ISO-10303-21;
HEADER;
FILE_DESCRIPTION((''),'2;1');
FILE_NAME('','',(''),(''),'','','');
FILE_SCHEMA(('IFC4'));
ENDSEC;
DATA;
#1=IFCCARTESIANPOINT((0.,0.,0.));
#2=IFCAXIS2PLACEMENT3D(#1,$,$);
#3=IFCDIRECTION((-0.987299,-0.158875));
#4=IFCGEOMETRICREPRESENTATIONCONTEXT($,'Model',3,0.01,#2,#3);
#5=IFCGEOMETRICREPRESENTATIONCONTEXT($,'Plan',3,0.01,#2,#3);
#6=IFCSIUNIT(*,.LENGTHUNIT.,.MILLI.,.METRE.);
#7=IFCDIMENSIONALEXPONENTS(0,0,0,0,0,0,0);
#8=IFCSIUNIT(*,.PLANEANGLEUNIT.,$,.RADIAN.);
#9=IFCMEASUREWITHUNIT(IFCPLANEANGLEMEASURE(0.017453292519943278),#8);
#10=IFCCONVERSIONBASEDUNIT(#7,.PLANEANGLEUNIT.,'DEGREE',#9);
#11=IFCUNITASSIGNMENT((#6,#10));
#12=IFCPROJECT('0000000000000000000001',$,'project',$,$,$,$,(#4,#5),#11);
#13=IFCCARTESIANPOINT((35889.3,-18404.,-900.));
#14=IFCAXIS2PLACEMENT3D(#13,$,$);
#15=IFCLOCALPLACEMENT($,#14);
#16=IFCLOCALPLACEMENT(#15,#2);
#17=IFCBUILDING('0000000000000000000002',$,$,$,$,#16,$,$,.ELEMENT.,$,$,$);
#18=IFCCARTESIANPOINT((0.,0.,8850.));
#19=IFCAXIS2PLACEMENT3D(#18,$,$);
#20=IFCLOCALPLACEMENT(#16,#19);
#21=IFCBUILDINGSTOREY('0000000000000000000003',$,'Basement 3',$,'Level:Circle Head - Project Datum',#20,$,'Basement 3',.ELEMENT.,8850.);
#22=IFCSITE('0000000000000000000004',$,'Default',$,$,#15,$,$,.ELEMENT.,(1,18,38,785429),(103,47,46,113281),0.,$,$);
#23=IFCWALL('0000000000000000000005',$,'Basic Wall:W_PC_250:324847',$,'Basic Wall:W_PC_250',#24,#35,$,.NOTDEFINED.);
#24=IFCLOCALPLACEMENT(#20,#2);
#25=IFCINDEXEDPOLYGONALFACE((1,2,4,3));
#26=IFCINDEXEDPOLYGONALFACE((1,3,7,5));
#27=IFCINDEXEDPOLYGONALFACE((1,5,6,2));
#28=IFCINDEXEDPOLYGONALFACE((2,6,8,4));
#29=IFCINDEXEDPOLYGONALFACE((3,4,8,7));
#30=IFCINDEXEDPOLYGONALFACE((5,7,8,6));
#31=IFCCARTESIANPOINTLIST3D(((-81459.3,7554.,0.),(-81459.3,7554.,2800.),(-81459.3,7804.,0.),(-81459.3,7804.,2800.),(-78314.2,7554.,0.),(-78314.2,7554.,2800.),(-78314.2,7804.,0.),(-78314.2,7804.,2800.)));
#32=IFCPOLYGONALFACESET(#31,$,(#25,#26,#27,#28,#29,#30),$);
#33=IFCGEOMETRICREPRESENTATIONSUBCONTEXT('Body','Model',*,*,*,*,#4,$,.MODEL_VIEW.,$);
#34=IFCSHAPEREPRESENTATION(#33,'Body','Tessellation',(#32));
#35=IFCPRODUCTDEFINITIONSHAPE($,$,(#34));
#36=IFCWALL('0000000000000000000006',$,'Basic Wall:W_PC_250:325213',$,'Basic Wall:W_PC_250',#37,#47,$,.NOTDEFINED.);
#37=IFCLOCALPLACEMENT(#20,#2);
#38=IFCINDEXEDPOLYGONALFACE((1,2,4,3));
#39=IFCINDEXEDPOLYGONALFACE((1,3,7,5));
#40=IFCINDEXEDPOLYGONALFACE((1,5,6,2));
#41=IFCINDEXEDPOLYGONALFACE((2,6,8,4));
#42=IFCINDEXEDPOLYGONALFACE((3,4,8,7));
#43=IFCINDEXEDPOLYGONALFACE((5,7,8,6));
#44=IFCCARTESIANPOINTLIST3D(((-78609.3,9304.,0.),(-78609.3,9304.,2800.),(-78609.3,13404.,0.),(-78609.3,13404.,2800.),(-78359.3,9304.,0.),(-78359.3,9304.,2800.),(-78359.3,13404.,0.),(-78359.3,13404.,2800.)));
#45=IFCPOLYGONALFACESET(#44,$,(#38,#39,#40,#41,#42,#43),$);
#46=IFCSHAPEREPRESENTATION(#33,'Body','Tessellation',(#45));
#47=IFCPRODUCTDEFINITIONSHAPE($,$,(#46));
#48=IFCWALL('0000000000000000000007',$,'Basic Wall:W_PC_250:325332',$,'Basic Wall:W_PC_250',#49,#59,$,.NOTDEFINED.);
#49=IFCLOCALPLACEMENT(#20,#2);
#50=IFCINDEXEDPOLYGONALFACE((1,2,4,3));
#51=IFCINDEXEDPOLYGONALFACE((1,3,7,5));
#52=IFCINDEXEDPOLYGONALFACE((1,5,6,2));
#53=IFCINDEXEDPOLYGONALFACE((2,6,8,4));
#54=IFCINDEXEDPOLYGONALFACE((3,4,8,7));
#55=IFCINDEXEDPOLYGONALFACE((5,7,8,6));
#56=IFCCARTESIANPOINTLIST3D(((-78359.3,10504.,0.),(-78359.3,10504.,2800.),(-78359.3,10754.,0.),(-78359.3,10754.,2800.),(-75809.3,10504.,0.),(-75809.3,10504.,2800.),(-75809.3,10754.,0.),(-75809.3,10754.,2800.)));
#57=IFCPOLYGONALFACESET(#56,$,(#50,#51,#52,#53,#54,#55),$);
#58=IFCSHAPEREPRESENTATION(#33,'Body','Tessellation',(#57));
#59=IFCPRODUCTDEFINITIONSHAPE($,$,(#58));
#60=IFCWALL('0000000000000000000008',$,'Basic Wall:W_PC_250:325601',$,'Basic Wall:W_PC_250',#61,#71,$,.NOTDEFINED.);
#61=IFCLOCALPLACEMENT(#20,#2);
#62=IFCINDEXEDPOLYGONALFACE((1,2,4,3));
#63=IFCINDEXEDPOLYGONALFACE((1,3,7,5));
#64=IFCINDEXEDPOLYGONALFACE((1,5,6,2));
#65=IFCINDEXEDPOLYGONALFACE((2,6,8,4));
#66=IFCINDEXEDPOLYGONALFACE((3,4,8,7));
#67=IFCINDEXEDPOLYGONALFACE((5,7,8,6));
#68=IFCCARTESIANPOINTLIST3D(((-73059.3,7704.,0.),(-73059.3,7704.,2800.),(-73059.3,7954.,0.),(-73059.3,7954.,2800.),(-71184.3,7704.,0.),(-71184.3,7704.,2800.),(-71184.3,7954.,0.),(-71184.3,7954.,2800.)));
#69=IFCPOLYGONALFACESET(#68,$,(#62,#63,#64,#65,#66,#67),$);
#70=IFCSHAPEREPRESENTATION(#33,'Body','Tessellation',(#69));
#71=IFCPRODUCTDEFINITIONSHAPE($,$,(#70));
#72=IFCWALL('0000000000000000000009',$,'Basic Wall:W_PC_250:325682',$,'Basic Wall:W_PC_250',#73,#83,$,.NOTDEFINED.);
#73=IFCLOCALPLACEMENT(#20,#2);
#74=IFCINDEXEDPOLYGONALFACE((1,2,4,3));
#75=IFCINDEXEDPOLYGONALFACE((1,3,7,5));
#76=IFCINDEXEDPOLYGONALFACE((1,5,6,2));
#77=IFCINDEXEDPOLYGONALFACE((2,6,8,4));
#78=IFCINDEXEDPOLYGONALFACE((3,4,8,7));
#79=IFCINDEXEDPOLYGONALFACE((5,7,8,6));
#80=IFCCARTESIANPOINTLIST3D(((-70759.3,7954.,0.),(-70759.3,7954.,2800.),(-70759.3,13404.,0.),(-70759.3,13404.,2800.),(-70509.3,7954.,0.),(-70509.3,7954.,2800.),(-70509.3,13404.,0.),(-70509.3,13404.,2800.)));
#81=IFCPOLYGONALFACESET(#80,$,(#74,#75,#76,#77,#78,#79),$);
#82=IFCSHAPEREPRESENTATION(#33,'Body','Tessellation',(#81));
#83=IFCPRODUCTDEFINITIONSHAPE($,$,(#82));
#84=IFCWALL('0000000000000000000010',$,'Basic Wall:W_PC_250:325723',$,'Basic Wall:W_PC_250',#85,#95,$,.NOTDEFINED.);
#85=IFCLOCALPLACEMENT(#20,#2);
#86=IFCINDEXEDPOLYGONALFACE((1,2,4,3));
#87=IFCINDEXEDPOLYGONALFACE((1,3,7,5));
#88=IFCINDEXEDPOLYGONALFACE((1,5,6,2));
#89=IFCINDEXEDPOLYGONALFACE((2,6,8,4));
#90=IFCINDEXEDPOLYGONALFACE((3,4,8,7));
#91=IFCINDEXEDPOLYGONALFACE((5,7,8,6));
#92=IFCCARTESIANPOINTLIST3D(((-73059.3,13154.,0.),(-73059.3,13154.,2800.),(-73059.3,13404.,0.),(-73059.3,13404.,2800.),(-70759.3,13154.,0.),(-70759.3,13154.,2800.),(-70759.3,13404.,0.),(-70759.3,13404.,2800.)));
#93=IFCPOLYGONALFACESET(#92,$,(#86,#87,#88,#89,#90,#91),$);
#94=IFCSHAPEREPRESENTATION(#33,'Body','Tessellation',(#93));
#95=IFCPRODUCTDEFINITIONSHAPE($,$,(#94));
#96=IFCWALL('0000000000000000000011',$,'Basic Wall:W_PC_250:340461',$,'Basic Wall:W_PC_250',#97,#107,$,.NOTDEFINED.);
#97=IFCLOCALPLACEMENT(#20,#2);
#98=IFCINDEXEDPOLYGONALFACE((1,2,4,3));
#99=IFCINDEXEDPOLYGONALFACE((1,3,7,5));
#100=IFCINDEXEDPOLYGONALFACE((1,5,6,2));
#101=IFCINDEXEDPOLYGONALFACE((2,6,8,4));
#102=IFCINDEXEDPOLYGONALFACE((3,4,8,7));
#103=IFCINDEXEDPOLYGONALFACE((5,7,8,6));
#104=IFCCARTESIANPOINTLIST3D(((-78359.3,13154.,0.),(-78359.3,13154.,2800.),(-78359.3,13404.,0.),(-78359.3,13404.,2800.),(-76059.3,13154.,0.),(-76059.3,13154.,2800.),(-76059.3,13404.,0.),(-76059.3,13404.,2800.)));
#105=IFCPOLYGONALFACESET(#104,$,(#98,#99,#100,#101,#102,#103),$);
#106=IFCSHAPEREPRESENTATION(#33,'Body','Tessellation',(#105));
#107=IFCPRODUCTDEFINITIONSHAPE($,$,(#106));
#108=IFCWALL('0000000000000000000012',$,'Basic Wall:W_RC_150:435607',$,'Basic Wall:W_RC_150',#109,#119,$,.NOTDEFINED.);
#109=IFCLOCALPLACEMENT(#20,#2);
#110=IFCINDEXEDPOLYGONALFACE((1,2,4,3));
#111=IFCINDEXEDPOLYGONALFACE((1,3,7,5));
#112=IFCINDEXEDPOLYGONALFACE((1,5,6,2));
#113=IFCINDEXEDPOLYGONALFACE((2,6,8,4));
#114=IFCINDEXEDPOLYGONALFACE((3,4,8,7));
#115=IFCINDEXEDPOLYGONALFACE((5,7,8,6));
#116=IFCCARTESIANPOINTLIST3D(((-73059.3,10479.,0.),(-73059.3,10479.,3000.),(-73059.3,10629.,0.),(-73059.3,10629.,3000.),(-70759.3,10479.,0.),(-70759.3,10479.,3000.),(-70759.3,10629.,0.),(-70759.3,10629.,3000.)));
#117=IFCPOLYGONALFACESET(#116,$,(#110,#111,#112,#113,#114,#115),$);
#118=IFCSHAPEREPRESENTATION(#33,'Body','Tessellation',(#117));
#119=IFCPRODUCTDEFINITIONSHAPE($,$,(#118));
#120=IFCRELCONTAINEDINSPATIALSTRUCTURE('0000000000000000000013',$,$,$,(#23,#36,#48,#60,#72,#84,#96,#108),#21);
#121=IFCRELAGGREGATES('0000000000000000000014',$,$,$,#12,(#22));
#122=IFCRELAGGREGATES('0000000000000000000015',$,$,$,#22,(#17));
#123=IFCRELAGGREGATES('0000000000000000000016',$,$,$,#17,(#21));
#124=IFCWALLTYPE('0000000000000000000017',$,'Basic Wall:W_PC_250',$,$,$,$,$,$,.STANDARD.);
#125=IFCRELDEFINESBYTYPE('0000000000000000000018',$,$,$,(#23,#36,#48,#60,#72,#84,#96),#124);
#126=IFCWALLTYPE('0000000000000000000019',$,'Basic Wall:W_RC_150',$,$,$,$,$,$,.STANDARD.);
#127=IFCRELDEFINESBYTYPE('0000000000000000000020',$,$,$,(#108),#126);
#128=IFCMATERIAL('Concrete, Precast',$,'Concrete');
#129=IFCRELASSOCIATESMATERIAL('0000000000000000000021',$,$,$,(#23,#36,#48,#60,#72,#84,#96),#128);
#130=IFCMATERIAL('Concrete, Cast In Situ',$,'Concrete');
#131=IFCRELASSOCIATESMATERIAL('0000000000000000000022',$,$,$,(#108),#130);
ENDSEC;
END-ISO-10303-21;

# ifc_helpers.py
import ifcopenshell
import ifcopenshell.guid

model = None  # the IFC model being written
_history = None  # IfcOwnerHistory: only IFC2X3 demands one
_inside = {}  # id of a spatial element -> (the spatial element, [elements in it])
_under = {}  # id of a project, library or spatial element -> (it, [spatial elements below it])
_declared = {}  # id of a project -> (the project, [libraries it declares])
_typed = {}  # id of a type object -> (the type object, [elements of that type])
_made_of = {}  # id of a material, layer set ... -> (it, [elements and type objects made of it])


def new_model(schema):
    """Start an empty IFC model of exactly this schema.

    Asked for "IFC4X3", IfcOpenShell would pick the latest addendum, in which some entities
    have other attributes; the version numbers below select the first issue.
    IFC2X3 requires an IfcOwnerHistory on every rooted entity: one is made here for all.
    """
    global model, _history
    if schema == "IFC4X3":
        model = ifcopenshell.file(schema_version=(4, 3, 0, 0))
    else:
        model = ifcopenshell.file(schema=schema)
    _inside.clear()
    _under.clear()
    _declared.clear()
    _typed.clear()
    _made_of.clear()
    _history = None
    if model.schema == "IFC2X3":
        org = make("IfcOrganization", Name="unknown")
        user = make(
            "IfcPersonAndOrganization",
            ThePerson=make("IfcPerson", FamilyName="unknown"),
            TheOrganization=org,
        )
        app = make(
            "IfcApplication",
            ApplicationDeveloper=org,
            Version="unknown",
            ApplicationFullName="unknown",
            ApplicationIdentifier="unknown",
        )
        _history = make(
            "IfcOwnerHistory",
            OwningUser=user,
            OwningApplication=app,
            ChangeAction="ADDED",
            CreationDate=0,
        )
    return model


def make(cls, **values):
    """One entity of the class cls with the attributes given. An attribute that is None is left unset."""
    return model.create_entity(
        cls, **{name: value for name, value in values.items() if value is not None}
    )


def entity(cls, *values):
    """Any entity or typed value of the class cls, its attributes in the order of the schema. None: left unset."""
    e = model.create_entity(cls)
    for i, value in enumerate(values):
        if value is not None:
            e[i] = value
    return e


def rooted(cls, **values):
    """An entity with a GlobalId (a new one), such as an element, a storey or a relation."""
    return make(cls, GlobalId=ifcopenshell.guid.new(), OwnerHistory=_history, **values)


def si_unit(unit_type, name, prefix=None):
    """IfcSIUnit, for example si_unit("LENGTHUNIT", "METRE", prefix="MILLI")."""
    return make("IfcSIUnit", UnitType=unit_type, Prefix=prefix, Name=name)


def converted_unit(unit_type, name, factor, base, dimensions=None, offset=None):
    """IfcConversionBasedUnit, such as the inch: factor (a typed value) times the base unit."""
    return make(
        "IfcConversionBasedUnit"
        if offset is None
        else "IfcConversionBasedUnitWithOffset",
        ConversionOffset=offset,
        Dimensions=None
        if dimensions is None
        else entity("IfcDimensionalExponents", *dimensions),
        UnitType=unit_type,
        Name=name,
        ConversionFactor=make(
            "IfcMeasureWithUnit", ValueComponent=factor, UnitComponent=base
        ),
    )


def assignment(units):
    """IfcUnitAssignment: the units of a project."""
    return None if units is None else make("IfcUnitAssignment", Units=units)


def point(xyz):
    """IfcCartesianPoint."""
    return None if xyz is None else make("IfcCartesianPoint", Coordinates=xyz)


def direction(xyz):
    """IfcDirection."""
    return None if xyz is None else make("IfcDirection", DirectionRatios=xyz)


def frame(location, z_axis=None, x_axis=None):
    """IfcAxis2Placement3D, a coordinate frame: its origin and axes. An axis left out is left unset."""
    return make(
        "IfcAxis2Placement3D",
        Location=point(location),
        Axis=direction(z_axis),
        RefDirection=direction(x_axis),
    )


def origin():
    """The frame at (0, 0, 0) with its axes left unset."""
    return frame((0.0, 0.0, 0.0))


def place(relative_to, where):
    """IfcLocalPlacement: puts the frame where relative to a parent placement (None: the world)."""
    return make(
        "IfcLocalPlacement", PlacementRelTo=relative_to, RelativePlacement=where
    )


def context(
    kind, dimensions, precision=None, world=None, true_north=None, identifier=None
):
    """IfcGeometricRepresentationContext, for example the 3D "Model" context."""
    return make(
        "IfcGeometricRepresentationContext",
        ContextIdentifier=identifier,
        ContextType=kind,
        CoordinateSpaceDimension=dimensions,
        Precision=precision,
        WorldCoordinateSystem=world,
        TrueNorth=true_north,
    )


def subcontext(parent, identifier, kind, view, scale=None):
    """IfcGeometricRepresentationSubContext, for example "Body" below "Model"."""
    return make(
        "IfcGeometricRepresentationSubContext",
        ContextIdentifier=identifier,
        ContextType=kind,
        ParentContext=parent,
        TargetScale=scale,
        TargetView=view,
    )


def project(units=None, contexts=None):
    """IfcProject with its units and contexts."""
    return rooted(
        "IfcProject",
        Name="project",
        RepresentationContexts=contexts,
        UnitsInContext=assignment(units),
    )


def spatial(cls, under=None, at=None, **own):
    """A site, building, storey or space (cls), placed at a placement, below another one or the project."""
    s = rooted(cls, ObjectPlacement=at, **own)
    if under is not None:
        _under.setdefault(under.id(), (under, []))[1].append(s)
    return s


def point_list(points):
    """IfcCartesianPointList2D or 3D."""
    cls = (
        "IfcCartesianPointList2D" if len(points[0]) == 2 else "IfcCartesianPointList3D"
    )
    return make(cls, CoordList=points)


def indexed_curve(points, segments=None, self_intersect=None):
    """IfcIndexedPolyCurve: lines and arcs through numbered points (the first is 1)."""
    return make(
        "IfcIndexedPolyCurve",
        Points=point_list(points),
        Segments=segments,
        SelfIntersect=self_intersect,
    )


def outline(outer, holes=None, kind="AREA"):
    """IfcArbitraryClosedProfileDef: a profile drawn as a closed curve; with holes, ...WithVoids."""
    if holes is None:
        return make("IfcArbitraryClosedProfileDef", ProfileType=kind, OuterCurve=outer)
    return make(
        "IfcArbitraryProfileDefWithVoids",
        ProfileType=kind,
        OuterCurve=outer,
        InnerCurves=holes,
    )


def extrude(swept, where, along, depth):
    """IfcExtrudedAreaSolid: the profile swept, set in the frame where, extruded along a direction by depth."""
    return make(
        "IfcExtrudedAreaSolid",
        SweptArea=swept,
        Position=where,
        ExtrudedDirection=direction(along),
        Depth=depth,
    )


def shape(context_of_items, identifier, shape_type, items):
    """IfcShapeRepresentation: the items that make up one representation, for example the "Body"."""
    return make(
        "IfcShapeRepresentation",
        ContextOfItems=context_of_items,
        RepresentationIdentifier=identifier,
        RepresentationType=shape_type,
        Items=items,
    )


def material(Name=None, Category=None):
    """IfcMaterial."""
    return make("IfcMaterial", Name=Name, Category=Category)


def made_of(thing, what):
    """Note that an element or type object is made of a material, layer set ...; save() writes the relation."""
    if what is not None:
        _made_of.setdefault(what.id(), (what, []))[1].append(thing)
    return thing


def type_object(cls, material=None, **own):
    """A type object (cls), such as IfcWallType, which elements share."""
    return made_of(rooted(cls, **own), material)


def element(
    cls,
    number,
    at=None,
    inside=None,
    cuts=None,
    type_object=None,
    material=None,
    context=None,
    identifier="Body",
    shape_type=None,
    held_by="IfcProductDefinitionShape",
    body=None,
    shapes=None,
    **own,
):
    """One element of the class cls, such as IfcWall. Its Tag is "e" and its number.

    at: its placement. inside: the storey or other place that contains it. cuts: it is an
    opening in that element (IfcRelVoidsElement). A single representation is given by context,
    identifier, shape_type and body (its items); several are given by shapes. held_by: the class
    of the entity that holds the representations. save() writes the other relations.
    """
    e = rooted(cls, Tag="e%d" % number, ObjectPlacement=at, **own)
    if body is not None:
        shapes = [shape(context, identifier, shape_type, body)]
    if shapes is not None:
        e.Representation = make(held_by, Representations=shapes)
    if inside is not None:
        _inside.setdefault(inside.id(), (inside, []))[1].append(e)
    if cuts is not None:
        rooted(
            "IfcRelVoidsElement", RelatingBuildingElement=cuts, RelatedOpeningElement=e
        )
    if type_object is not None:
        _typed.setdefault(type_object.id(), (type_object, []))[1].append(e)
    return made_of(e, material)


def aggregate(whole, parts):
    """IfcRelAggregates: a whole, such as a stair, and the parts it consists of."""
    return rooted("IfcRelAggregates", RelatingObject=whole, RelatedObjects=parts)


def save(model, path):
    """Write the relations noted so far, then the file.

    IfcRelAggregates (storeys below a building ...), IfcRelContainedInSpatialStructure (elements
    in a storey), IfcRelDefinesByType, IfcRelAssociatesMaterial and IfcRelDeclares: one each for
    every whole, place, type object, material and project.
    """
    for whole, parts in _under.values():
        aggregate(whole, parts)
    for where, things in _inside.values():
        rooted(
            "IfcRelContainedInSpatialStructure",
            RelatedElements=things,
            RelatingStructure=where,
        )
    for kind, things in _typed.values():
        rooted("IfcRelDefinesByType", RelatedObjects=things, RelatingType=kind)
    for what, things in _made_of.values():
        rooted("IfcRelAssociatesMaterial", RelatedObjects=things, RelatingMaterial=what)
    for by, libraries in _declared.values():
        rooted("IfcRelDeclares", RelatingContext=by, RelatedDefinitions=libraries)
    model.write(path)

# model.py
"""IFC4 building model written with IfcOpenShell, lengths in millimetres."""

from ifc_helpers import new_model, entity, si_unit, converted_unit, direction, frame, origin, place, context, subcontext, project, spatial, indexed_curve, outline, extrude, material, type_object, element, save


model = new_model("IFC4")

# Units and contexts
model_context = context("Model", 3, precision=0.01, world=origin(), true_north=direction((-0.987299, -0.158875)))
plan_context = context("Plan", 3, precision=0.01, world=origin(), true_north=direction((-0.987299, -0.158875)))
body_context = subcontext(model_context, "Body", "Model", "MODEL_VIEW")
ifc_project = project(units=[si_unit("LENGTHUNIT", "METRE", prefix="MILLI"), converted_unit("PLANEANGLEUNIT", "DEGREE", entity("IfcPlaneAngleMeasure", 0.017453292519943278), si_unit("PLANEANGLEUNIT", "RADIAN"), dimensions=[0, 0, 0, 0, 0, 0, 0])], contexts=[model_context, plan_context])

# Site, building, storey
site_placement = place(None, frame((35889.3, -18404.0, -900.0)))
site = spatial("IfcSite", under=ifc_project, at=site_placement, Name="Default", CompositionType="ELEMENT", RefLatitude=(1, 18, 38, 785429), RefLongitude=(103, 47, 46, 113281), RefElevation=0.0)
building_placement = place(site_placement, origin())
building = spatial("IfcBuilding", under=site, at=building_placement, CompositionType="ELEMENT")
storey_placement = place(building_placement, frame((0.0, 0.0, 8850.0)))
storey = spatial("IfcBuildingStorey", under=building, at=storey_placement, Name="Basement 3", ObjectType="Level:Circle Head - Project Datum", LongName="Basement 3", CompositionType="ELEMENT", Elevation=8850.0)

# Walls
ifc_material_1 = material(Name="Concrete, Cast In Situ", Category="Concrete")
ifc_material_2 = material(Name="Concrete, Precast", Category="Concrete")
wall_type_1 = type_object("IfcWallType", Name="Basic Wall:W_PC_250", PredefinedType="STANDARD")
wall_1_placement = place(storey_placement, frame((-81459.3, 7679.0, 0.0)))
element("IfcWall", 1, at=wall_1_placement, inside=storey, type_object=wall_type_1, material=ifc_material_2, Name="Basic Wall:W_PC_250:324847", ObjectType="Basic Wall:W_PC_250", PredefinedType="NOTDEFINED", context=body_context, shape_type="SweptSolid", body=[
    extrude(outline(indexed_curve([(3145.2, 125.0), (0.0, 125.0), (0.0, -125.0), (3145.2, -125.0), (3145.2, 125.0)], self_intersect=False)), origin(), (0.0, 0.0, 1.0), 2800.0),
])
wall_2_placement = place(storey_placement, frame((-78484.3, 9304.0, 0.0), z_axis=(0.0, 0.0, 1.0), x_axis=(0.0, 1.0, 0.0)))
element("IfcWall", 2, at=wall_2_placement, inside=storey, type_object=wall_type_1, material=ifc_material_2, Name="Basic Wall:W_PC_250:325213", ObjectType="Basic Wall:W_PC_250", PredefinedType="NOTDEFINED", context=body_context, shape_type="SweptSolid", body=[
    extrude(outline(indexed_curve([(4100.0, 125.0), (0.0, 125.0), (0.0, -125.0), (4100.0, -125.0), (4100.0, 125.0)], self_intersect=False)), origin(), (0.0, 0.0, 1.0), 2800.0),
])
wall_3_placement = place(storey_placement, frame((-78359.3, 10629.0, 0.0)))
element("IfcWall", 3, at=wall_3_placement, inside=storey, type_object=wall_type_1, material=ifc_material_2, Name="Basic Wall:W_PC_250:325332", ObjectType="Basic Wall:W_PC_250", PredefinedType="NOTDEFINED", context=body_context, shape_type="SweptSolid", body=[
    extrude(outline(indexed_curve([(2550.0, 125.0), (0.0, 125.0), (0.0, -125.0), (2550.0, -125.0), (2550.0, 125.0)], self_intersect=False)), origin(), (0.0, 0.0, 1.0), 2800.0),
])
wall_4_placement = place(storey_placement, frame((-73059.3, 7829.0, 0.0)))
element("IfcWall", 4, at=wall_4_placement, inside=storey, type_object=wall_type_1, material=ifc_material_2, Name="Basic Wall:W_PC_250:325601", ObjectType="Basic Wall:W_PC_250", PredefinedType="NOTDEFINED", context=body_context, shape_type="SweptSolid", body=[
    extrude(outline(indexed_curve([(1875.0, 125.0), (0.0, 125.0), (0.0, -125.0), (1875.0, -125.0), (1875.0, 125.0)], self_intersect=False)), origin(), (0.0, 0.0, 1.0), 2800.0),
])
wall_5_placement = place(storey_placement, frame((-70634.3, 7954.0, 0.0), z_axis=(0.0, 0.0, 1.0), x_axis=(0.0, 1.0, 0.0)))
element("IfcWall", 5, at=wall_5_placement, inside=storey, type_object=wall_type_1, material=ifc_material_2, Name="Basic Wall:W_PC_250:325682", ObjectType="Basic Wall:W_PC_250", PredefinedType="NOTDEFINED", context=body_context, shape_type="SweptSolid", body=[
    extrude(outline(indexed_curve([(5450.0, 125.0), (0.0, 125.0), (0.0, -125.0), (5450.0, -125.0), (5450.0, 125.0)], self_intersect=False)), origin(), (0.0, 0.0, 1.0), 2800.0),
])
wall_6_placement = place(storey_placement, frame((-73059.3, 13279.0, 0.0)))
element("IfcWall", 6, at=wall_6_placement, inside=storey, type_object=wall_type_1, material=ifc_material_2, Name="Basic Wall:W_PC_250:325723", ObjectType="Basic Wall:W_PC_250", PredefinedType="NOTDEFINED", context=body_context, shape_type="SweptSolid", body=[
    extrude(outline(indexed_curve([(2300.0, 125.0), (0.0, 125.0), (0.0, -125.0), (2300.0, -125.0), (2300.0, 125.0)], self_intersect=False)), origin(), (0.0, 0.0, 1.0), 2800.0),
])
wall_7_placement = place(storey_placement, frame((-78359.3, 13279.0, 0.0)))
element("IfcWall", 7, at=wall_7_placement, inside=storey, type_object=wall_type_1, material=ifc_material_2, Name="Basic Wall:W_PC_250:340461", ObjectType="Basic Wall:W_PC_250", PredefinedType="NOTDEFINED", context=body_context, shape_type="SweptSolid", body=[
    extrude(outline(indexed_curve([(2300.0, 125.0), (0.0, 125.0), (0.0, -125.0), (2300.0, -125.0), (2300.0, 125.0)], self_intersect=False)), origin(), (0.0, 0.0, 1.0), 2800.0),
])
wall_type_2 = type_object("IfcWallType", Name="Basic Wall:W_RC_150", PredefinedType="STANDARD")
wall_8_placement = place(storey_placement, frame((-70759.3, 10554.0, 0.0), z_axis=(0.0, 0.0, 1.0), x_axis=(-1.0, 0.0, 0.0)))
element("IfcWall", 8, at=wall_8_placement, inside=storey, type_object=wall_type_2, material=ifc_material_1, Name="Basic Wall:W_RC_150:435607", ObjectType="Basic Wall:W_RC_150", PredefinedType="NOTDEFINED", context=body_context, shape_type="SweptSolid", body=[
    extrude(outline(indexed_curve([(2300.0, 75.0), (0.0, 75.0), (0.0, -75.0), (2300.0, -75.0), (2300.0, 75.0)], self_intersect=False)), origin(), (0.0, 0.0, 1.0), 3000.0),
])

save(model, "model.ifc")
